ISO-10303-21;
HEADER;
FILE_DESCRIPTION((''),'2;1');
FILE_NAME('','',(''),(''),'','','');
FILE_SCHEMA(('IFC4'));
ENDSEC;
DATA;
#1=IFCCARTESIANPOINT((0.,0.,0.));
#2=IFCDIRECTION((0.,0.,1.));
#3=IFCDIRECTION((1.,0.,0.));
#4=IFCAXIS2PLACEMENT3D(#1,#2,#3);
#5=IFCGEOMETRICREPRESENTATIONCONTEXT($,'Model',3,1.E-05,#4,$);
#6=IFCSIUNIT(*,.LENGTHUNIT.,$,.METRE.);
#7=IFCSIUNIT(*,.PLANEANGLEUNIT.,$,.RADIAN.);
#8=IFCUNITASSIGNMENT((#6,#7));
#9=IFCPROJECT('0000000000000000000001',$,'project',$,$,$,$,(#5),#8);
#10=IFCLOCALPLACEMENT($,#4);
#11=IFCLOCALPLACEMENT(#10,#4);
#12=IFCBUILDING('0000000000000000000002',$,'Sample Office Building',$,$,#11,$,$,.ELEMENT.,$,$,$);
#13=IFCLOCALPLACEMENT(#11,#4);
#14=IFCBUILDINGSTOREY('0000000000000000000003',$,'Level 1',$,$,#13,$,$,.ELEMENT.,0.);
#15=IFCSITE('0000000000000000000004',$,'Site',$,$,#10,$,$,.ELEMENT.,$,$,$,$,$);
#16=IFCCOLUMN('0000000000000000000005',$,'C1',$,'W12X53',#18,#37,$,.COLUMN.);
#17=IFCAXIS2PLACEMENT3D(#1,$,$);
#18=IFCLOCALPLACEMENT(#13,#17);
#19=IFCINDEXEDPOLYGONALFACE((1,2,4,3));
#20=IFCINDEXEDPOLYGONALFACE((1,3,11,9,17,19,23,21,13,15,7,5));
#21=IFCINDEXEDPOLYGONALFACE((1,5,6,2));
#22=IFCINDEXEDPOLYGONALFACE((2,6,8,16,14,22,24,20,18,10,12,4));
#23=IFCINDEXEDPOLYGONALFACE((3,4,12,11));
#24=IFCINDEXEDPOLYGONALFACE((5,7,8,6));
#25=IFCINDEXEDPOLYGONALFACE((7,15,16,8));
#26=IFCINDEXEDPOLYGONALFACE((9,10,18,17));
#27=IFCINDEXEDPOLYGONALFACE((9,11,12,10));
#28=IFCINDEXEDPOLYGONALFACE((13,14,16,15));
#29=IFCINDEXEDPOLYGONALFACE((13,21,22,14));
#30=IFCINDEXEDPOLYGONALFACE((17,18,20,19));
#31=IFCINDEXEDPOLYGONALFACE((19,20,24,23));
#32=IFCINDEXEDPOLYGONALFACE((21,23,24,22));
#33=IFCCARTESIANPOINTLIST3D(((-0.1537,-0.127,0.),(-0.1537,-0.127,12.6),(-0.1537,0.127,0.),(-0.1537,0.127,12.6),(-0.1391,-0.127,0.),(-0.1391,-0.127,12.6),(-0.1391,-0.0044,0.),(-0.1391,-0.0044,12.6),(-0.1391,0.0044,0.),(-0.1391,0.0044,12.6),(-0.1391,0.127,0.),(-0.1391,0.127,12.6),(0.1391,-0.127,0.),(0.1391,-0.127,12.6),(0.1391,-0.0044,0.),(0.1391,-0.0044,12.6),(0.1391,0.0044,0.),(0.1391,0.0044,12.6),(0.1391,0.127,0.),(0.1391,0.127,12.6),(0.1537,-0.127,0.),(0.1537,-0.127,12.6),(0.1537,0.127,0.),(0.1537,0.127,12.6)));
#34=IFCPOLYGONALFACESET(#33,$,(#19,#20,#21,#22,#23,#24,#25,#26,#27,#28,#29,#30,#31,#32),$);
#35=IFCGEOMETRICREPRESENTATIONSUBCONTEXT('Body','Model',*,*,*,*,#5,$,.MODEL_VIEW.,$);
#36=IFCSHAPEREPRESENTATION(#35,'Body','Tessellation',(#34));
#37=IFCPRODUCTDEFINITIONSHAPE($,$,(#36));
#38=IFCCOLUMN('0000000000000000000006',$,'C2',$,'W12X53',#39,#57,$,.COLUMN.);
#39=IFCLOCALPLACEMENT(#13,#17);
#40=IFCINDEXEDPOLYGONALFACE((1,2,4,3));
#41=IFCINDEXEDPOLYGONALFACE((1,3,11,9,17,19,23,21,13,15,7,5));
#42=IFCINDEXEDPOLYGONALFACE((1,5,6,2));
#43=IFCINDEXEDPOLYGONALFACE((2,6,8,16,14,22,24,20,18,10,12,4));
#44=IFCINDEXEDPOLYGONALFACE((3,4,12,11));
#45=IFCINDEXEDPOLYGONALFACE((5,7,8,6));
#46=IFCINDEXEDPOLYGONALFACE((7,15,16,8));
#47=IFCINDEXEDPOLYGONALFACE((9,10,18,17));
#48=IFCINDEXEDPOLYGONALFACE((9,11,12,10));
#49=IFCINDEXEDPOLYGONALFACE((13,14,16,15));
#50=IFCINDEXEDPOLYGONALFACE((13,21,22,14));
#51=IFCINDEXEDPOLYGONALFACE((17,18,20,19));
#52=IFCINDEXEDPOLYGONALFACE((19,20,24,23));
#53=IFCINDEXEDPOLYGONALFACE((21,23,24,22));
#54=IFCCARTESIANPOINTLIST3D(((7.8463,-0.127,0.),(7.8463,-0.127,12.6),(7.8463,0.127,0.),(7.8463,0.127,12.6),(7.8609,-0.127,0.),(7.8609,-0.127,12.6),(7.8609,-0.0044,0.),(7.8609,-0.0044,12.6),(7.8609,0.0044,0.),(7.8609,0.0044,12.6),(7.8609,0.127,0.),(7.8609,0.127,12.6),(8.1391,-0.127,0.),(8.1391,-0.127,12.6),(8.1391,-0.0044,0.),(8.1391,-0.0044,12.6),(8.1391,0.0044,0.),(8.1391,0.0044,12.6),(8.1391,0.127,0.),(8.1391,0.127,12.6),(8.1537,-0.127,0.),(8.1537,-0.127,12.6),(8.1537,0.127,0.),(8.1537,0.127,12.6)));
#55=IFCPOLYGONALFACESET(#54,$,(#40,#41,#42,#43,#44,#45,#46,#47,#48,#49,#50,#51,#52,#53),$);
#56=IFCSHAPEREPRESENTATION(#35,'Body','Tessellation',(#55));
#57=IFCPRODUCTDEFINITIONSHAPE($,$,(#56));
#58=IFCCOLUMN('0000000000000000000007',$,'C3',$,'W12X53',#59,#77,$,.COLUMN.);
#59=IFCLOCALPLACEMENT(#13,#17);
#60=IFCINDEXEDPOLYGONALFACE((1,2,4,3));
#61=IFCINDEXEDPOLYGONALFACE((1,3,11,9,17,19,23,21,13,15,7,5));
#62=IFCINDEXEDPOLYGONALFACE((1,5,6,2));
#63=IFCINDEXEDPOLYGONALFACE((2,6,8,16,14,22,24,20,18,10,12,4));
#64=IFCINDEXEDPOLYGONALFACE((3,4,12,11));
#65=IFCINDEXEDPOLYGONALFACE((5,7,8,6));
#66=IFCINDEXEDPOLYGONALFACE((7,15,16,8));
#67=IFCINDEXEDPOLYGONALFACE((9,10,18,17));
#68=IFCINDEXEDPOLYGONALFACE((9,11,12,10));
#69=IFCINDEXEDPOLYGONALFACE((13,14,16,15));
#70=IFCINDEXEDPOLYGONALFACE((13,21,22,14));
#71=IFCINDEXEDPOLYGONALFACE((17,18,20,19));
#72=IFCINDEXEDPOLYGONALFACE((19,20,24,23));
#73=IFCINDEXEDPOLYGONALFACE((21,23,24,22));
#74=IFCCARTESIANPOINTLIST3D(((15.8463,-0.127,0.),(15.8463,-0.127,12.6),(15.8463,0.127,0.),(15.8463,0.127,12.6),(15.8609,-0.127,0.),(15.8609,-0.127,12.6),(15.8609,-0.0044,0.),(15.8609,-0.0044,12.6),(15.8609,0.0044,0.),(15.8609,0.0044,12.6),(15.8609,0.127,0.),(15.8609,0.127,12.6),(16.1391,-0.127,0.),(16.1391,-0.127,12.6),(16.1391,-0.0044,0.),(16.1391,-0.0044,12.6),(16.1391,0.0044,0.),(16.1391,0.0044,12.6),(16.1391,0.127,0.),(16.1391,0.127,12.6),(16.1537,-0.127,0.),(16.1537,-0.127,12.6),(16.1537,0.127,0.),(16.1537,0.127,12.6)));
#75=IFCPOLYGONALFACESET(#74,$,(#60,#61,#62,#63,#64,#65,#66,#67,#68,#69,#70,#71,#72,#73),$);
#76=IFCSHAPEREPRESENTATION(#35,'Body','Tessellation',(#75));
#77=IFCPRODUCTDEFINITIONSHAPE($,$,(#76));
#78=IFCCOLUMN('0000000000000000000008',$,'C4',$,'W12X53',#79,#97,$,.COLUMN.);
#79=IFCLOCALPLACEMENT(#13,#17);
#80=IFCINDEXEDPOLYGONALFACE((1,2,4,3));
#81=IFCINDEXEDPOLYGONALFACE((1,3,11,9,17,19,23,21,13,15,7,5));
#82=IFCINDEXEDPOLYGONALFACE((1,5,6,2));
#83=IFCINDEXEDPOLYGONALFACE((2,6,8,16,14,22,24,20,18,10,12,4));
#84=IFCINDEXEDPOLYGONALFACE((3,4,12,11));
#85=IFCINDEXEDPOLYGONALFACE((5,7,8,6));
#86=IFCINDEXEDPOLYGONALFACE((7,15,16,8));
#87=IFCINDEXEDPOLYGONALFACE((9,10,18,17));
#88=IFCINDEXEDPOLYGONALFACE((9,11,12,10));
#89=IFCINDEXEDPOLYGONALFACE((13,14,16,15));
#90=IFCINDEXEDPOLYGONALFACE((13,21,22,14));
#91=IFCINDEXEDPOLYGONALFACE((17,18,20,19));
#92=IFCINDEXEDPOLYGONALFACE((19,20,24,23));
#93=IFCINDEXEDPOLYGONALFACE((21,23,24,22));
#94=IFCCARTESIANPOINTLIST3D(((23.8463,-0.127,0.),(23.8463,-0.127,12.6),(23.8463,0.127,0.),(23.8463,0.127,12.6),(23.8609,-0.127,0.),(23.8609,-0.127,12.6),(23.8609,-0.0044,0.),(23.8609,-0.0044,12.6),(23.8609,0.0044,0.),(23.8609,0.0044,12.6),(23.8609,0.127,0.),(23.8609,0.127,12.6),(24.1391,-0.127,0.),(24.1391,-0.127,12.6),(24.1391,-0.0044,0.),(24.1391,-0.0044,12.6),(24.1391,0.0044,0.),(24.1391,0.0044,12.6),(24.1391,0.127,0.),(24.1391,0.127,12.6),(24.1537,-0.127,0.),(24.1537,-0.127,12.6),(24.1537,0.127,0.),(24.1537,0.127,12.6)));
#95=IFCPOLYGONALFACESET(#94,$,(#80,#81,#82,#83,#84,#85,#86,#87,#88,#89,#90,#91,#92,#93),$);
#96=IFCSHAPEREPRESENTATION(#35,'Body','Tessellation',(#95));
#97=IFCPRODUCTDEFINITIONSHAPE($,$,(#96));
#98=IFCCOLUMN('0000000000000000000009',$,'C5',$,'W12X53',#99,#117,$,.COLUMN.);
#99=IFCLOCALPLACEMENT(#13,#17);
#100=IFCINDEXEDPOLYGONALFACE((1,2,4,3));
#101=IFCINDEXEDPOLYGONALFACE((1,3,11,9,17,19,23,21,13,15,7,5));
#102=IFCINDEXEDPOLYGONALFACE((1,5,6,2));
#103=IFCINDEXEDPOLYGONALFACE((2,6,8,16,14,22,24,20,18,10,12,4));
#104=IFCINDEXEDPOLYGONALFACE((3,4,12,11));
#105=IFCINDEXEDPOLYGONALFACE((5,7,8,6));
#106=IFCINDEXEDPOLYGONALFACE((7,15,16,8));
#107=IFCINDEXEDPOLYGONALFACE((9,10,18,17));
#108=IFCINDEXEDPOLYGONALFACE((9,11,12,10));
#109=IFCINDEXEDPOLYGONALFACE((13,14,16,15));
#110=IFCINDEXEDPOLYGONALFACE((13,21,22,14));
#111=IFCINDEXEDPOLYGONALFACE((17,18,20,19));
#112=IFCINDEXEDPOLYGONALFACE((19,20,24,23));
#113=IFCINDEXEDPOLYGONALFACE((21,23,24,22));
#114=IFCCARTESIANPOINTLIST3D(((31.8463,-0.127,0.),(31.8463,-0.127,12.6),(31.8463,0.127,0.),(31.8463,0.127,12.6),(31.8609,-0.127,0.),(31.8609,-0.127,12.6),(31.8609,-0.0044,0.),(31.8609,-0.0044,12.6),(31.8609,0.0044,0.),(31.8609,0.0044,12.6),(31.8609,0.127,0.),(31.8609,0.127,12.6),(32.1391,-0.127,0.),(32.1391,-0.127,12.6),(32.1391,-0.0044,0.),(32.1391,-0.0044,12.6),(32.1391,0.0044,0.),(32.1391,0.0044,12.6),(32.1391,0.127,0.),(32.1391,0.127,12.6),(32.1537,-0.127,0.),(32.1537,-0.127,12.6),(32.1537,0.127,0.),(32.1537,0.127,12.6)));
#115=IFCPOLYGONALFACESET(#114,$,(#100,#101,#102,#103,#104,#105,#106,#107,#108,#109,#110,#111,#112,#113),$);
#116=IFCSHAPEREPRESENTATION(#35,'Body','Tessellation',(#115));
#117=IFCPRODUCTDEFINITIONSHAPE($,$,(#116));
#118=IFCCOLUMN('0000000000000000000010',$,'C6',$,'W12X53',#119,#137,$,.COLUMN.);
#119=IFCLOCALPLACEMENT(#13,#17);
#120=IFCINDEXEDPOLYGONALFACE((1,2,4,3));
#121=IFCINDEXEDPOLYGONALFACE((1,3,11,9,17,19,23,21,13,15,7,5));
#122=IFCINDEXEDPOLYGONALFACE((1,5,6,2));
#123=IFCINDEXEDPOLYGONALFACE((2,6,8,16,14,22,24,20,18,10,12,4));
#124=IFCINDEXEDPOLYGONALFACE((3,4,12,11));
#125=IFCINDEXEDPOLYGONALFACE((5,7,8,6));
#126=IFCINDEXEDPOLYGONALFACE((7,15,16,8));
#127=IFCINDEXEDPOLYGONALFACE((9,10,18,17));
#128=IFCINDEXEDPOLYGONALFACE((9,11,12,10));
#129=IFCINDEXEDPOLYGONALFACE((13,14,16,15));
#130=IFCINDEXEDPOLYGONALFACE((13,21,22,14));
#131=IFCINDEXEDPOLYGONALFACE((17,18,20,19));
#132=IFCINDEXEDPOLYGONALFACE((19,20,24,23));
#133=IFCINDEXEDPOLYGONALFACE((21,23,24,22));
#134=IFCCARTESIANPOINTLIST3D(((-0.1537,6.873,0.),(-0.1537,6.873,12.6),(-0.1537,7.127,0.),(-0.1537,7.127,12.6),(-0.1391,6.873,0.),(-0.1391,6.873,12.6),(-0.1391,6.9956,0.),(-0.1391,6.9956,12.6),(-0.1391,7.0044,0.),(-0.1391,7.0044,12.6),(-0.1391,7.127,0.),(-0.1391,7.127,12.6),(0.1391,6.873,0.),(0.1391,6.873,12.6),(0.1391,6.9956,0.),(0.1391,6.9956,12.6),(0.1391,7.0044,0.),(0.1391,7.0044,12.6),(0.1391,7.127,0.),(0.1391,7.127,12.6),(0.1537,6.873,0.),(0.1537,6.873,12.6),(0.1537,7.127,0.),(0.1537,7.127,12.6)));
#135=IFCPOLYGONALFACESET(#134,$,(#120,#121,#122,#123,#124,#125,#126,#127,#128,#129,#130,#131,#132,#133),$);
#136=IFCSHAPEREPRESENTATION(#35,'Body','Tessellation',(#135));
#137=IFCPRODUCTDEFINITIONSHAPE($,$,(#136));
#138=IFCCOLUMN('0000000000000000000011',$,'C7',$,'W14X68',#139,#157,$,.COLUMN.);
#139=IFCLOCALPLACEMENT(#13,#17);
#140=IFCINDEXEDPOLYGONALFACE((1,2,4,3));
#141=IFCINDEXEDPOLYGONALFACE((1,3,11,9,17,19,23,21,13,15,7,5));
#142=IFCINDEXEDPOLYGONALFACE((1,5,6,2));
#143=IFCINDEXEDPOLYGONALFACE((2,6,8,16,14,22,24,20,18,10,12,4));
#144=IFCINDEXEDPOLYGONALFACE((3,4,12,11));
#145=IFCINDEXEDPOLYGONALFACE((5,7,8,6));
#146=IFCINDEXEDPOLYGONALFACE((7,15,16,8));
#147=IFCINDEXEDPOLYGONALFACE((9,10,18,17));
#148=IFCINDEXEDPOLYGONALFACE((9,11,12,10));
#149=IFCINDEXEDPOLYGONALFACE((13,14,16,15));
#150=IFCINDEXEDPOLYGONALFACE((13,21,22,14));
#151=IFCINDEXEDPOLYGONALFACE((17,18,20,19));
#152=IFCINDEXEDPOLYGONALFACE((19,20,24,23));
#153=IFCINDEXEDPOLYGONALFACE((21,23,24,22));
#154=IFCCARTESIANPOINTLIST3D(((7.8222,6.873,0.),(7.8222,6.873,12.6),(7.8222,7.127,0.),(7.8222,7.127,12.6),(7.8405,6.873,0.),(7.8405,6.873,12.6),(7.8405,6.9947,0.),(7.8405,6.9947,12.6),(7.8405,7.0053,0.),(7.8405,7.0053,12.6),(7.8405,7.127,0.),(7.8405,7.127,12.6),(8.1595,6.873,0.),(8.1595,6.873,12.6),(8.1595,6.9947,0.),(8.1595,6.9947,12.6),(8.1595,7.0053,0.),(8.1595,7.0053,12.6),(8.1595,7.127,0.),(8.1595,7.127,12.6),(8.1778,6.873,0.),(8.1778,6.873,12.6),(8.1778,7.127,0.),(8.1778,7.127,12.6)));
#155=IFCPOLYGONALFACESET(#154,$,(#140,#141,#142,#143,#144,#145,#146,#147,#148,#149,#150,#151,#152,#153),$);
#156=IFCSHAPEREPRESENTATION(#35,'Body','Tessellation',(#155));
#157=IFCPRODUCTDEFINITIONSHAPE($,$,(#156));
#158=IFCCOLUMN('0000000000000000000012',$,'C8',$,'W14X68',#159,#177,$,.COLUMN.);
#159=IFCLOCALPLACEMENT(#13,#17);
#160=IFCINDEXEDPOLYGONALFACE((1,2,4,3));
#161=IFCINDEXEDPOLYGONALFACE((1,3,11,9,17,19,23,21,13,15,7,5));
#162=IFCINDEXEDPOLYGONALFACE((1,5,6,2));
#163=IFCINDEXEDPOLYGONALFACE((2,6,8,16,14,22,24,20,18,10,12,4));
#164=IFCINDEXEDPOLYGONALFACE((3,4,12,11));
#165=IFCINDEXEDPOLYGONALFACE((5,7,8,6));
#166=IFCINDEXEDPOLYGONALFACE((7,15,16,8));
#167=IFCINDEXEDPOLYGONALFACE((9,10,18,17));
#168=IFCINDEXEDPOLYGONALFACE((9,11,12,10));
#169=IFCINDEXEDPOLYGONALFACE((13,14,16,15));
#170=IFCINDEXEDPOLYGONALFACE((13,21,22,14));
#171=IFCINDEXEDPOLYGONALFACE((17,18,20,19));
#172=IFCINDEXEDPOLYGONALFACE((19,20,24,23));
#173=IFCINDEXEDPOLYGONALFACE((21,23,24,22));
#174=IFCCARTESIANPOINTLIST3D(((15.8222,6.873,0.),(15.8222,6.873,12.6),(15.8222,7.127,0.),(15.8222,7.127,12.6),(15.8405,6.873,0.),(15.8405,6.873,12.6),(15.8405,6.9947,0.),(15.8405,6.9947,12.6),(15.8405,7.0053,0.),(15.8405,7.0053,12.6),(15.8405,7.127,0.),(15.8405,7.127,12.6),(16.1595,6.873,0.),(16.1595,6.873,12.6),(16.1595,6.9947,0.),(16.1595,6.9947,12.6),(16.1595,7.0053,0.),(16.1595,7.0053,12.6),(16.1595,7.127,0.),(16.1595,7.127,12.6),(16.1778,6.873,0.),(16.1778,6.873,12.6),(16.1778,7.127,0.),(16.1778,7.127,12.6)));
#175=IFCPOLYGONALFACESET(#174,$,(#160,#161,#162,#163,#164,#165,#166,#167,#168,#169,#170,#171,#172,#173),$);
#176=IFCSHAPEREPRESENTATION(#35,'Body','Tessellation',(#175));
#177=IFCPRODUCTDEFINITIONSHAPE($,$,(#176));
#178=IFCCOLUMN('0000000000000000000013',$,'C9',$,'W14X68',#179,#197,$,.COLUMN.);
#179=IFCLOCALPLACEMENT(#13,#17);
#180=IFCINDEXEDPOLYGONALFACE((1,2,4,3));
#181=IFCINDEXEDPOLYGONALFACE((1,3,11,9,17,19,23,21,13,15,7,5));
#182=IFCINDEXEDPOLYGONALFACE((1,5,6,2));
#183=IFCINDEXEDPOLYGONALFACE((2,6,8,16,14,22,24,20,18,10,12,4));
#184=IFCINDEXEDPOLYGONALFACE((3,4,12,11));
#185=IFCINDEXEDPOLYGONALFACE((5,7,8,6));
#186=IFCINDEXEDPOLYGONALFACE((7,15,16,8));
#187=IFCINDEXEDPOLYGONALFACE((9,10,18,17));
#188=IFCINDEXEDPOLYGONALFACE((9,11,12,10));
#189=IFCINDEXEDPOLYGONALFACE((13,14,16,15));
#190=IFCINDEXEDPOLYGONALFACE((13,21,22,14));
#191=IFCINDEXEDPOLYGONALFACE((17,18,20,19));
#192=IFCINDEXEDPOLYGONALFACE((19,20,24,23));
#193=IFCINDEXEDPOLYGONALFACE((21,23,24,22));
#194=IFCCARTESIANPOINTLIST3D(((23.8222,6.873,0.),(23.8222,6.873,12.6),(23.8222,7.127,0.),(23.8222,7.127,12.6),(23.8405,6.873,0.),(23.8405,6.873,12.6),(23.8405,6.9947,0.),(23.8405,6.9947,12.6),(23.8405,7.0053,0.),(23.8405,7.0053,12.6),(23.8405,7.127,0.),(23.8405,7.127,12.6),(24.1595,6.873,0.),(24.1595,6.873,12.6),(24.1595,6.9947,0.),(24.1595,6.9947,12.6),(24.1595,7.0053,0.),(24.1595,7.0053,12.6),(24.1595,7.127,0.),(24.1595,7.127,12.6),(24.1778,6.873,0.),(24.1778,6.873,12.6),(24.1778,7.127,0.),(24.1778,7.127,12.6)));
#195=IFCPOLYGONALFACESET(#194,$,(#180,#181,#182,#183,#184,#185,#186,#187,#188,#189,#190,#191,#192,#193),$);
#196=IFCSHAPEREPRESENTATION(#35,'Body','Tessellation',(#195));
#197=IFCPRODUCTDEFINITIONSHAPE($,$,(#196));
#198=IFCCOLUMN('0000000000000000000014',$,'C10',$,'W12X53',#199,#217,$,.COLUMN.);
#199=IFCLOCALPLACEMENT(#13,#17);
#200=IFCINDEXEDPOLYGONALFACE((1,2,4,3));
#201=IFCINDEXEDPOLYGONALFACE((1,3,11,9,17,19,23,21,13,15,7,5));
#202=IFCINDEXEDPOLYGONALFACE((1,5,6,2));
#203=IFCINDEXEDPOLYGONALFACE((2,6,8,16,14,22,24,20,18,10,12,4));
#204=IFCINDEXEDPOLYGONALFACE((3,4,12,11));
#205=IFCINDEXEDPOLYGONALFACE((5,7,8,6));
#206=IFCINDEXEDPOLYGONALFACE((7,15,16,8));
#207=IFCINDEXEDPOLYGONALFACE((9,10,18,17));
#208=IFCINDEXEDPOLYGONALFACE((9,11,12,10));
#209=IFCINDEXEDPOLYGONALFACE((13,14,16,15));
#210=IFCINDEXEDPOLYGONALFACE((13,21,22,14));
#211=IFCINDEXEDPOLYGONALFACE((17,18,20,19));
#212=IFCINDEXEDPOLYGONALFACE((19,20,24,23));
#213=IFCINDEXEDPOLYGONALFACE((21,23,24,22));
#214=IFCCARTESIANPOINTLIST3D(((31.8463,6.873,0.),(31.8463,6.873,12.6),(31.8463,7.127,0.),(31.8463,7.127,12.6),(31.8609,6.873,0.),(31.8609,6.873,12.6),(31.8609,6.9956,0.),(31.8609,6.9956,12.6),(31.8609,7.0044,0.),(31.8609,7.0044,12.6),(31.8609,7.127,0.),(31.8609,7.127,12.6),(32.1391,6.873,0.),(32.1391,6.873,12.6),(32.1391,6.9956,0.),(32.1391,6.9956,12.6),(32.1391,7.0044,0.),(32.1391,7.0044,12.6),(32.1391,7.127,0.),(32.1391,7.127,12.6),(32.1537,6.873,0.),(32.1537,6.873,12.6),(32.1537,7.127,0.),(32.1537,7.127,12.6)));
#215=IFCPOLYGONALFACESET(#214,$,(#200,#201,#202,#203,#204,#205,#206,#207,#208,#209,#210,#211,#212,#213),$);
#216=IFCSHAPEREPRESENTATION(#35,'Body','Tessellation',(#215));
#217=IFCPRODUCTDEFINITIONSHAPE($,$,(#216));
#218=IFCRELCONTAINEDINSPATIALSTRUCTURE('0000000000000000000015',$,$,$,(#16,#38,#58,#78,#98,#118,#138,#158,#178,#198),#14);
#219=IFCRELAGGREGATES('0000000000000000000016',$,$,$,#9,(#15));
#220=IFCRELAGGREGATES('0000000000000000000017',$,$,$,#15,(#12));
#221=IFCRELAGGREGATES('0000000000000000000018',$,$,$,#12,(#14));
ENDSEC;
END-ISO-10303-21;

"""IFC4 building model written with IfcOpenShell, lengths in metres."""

from ifc_helpers import new_model, si_unit, frame, origin_with_axes, place, context, subcontext, project, spatial, i_section, extrude, element, save


model = new_model("IFC4")

# Units and contexts
model_context = context("Model", 3, precision=1e-05, world=origin_with_axes())
body_context = subcontext(model_context, "Body", "Model", "MODEL_VIEW")
ifc_project = project(units=[si_unit("LENGTHUNIT", "METRE"), si_unit("PLANEANGLEUNIT", "RADIAN")], contexts=[model_context])

# Site, building, storey
site_placement = place(None, origin_with_axes())
site = spatial("IfcSite", under=ifc_project, at=site_placement, Name="Site", CompositionType="ELEMENT")
building_placement = place(site_placement, origin_with_axes())
building = spatial("IfcBuilding", under=site, at=building_placement, Name="Sample Office Building", CompositionType="ELEMENT")
storey_placement = place(building_placement, origin_with_axes())
storey = spatial("IfcBuildingStorey", under=building, at=storey_placement, Name="Level 1", CompositionType="ELEMENT", Elevation=0.0)

# Columns
for number, where, z_axis, x_axis, name in (
    (1, (0.0, 0.0, 0.0), (0.0, 0.0, 1.0), (0.0, 1.0, 0.0), "C1"),
    (2, (8.0, 0.0, 0.0), (0.0, 0.0, 1.0), (0.0, 1.0, 0.0), "C2"),
    (3, (16.0, 0.0, 0.0), (0.0, 0.0, 1.0), (0.0, 1.0, 0.0), "C3"),
    (4, (24.0, 0.0, 0.0), (0.0, 0.0, 1.0), (0.0, 1.0, 0.0), "C4"),
    (5, (32.0, 0.0, 0.0), (0.0, 0.0, 1.0), (0.0, 1.0, 0.0), "C5"),
    (6, (0.0, 7.0, 0.0), (0.0, 0.0, 1.0), (0.0, 1.0, 0.0), "C6"),
):
    element("IfcColumn", number, at=place(None, frame(where, z_axis=z_axis, x_axis=x_axis)), inside=storey, Name=name, ObjectType="W12X53", PredefinedType="COLUMN", context=body_context, shape_type="SweptSolid", body=[
        extrude(i_section(OverallWidth=0.254, OverallDepth=0.3073, WebThickness=0.0088, FlangeThickness=0.0146), None, (0.0, 0.0, 1.0), 12.6),
    ])
for number, where, z_axis, x_axis, name in (
    (7, (8.0, 7.0, 0.0), (0.0, 0.0, 1.0), (0.0, 1.0, 0.0), "C7"),
    (8, (16.0, 7.0, 0.0), (0.0, 0.0, 1.0), (0.0, 1.0, 0.0), "C8"),
    (9, (24.0, 7.0, 0.0), (0.0, 0.0, 1.0), (0.0, 1.0, 0.0), "C9"),
):
    element("IfcColumn", number, at=place(None, frame(where, z_axis=z_axis, x_axis=x_axis)), inside=storey, Name=name, ObjectType="W14X68", PredefinedType="COLUMN", context=body_context, shape_type="SweptSolid", body=[
        extrude(i_section(OverallWidth=0.254, OverallDepth=0.3556, WebThickness=0.0105, FlangeThickness=0.0183), None, (0.0, 0.0, 1.0), 12.6),
    ])
for number, where, z_axis, x_axis, name in (
    (10, (32.0, 7.0, 0.0), (0.0, 0.0, 1.0), (0.0, 1.0, 0.0), "C10"),
):
    element("IfcColumn", number, at=place(None, frame(where, z_axis=z_axis, x_axis=x_axis)), inside=storey, Name=name, ObjectType="W12X53", PredefinedType="COLUMN", context=body_context, shape_type="SweptSolid", body=[
        extrude(i_section(OverallWidth=0.254, OverallDepth=0.3073, WebThickness=0.0088, FlangeThickness=0.0146), None, (0.0, 0.0, 1.0), 12.6),
    ])

save(model, "model.ifc")
